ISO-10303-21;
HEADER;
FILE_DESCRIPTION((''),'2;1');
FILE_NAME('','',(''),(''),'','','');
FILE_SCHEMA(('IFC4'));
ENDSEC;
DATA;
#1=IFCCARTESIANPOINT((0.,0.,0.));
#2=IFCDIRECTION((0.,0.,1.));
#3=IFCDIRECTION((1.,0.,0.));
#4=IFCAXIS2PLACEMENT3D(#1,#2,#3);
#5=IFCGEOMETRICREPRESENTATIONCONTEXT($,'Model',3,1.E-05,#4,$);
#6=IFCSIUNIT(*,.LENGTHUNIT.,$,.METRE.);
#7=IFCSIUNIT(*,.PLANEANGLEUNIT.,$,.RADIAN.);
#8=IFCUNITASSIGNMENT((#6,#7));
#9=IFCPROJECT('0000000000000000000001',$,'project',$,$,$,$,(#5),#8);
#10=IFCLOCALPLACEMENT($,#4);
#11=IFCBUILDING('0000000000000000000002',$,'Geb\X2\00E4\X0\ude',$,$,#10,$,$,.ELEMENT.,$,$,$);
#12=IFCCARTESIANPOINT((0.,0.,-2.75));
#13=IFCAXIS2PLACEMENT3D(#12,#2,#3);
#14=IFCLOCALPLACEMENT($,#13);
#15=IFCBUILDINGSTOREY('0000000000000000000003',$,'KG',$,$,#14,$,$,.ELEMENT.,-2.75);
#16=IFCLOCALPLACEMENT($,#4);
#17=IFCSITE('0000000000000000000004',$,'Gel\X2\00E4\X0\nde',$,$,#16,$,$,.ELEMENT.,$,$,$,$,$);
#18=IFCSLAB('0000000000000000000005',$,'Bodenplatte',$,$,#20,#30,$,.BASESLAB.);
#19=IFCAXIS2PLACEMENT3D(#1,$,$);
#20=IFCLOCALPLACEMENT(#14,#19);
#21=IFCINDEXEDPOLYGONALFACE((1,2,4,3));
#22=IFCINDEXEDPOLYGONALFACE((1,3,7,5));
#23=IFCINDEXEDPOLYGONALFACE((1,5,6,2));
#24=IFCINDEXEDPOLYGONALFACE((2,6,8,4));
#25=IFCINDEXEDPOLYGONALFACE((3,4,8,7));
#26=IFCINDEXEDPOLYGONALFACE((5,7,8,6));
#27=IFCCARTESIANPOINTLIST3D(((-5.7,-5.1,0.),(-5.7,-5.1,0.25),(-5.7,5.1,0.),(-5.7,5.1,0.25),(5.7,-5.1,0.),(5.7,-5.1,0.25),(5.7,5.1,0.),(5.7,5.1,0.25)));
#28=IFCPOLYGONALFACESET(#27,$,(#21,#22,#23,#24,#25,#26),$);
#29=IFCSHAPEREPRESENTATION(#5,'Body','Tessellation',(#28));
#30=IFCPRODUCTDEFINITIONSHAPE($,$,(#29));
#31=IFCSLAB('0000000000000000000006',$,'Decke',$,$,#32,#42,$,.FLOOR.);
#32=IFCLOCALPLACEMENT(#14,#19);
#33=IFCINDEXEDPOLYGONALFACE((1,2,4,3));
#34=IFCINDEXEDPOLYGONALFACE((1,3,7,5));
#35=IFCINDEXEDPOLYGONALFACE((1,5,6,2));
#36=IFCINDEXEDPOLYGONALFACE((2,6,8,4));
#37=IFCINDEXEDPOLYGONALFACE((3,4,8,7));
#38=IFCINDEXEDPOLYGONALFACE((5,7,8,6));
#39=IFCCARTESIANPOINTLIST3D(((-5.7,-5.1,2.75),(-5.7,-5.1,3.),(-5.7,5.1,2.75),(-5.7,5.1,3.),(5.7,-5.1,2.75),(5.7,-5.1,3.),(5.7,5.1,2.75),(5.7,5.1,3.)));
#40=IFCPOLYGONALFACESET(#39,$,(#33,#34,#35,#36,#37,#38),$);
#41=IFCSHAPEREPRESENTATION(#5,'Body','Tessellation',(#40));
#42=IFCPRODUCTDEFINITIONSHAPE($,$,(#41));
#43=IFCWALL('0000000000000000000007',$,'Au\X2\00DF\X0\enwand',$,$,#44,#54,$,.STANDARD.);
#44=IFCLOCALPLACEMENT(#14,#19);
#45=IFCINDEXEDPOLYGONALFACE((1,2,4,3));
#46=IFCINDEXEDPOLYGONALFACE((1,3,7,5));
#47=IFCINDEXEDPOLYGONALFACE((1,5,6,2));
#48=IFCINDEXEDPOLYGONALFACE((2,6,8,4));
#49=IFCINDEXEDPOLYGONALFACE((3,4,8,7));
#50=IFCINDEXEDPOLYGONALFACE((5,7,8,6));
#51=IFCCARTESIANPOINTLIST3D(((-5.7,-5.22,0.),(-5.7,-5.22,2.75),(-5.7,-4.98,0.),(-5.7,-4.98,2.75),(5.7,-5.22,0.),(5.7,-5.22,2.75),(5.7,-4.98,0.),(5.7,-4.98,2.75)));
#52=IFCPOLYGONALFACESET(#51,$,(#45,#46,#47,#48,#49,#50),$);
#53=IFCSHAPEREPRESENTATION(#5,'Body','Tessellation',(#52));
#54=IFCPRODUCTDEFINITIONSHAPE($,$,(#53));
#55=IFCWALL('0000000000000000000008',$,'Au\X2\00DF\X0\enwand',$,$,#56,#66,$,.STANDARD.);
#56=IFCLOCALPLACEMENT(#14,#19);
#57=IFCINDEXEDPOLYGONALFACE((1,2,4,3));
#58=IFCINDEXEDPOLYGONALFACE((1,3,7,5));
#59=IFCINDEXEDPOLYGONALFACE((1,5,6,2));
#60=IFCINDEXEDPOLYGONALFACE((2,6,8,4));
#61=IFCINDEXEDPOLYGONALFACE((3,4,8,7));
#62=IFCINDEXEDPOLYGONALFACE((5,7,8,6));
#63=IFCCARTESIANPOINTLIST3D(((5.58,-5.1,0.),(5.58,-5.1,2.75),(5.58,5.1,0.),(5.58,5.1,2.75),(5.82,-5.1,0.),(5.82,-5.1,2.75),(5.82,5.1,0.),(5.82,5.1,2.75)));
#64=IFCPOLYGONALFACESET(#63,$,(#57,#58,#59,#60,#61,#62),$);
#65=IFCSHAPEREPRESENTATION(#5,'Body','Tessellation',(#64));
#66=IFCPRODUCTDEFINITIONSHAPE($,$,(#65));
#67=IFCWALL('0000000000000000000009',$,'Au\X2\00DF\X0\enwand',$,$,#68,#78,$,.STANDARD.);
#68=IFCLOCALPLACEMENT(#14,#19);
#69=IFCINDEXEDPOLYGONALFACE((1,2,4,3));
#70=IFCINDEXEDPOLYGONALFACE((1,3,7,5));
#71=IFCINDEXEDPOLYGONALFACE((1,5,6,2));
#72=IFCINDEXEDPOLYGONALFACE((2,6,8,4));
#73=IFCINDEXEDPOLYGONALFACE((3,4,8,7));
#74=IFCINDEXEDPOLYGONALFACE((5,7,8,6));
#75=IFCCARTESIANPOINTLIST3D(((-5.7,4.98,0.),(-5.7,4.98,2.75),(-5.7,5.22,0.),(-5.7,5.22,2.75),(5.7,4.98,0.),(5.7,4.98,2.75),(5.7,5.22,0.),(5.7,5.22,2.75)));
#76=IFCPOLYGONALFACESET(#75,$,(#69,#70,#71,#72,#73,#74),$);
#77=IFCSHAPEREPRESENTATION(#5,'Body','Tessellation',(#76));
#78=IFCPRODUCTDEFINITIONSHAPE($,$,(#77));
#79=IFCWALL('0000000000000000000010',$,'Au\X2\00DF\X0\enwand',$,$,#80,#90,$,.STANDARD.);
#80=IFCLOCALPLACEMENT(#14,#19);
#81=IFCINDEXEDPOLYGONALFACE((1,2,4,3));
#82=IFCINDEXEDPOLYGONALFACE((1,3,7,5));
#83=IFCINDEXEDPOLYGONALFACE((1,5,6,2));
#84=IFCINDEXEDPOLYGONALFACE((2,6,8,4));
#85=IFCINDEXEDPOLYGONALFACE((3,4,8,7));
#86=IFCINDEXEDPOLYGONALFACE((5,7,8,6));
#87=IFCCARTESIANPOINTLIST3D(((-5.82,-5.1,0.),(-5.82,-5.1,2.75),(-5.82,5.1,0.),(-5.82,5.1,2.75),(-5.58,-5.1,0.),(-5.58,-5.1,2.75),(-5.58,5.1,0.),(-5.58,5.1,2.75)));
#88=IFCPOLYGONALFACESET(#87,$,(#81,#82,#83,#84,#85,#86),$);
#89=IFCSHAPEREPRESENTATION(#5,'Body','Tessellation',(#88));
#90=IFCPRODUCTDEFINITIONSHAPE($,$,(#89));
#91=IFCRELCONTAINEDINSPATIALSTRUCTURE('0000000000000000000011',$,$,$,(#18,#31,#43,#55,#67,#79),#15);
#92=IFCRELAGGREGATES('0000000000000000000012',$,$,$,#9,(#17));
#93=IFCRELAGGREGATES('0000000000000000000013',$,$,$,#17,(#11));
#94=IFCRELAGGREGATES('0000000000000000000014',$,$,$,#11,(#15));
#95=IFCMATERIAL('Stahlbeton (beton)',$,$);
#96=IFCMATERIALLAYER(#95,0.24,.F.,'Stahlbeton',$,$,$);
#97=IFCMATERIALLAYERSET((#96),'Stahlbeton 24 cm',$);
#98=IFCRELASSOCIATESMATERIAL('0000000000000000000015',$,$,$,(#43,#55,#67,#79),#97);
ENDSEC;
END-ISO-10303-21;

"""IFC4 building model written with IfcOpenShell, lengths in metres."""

from ifc_helpers import new_model, si_unit, frame, origin_with_axes, origin_2d, place, context, project, spatial, polyline, rectangle, outline, extrude, material, layer, layer_set, element, save


model = new_model("IFC4")

# Units and contexts
model_context = context("Model", 3, precision=1e-05, world=origin_with_axes())
ifc_project = project(units=[si_unit("LENGTHUNIT", "METRE"), si_unit("PLANEANGLEUNIT", "RADIAN")], contexts=[model_context])

# Site, building, storey
site_placement = place(None, origin_with_axes())
site = spatial("IfcSite", under=ifc_project, at=site_placement, Name="Gelände", CompositionType="ELEMENT")
building_placement = place(None, origin_with_axes())
building = spatial("IfcBuilding", under=site, at=building_placement, Name="Gebäude", CompositionType="ELEMENT")
storey_placement = place(None, frame((0.0, 0.0, -2.75), z_axis=(0.0, 0.0, 1.0), x_axis=(1.0, 0.0, 0.0)))
storey = spatial("IfcBuildingStorey", under=building, at=storey_placement, Name="KG", CompositionType="ELEMENT", Elevation=-2.75)

# Slabs
slab_1_placement = place(None, frame((0.0, 0.0, -2.75), z_axis=(0.0, 0.0, 1.0), x_axis=(1.0, 0.0, 0.0)))
element("IfcSlab", 1, at=slab_1_placement, inside=storey, Name="Bodenplatte", PredefinedType="BASESLAB", context=model_context, shape_type="SweptSolid", body=[
    extrude(outline(polyline([(-5.7, -5.1), (5.7, -5.1), (5.7, 5.1), (-5.7, 5.1), (-5.7, -5.1)])), origin_with_axes(), (0.0, 0.0, 1.0), 0.25),
])
slab_2_placement = place(None, origin_with_axes())
element("IfcSlab", 2, at=slab_2_placement, inside=storey, Name="Decke", PredefinedType="FLOOR", context=model_context, shape_type="SweptSolid", body=[
    extrude(outline(polyline([(-5.7, -5.1), (5.7, -5.1), (5.7, 5.1), (-5.7, 5.1), (-5.7, -5.1)])), origin_with_axes(), (0.0, 0.0, 1.0), 0.25),
])

# Walls
ifc_material = material(Name="Stahlbeton (beton)")
ifc_layer = layer(ifc_material, 0.24, ventilated=False, Name="Stahlbeton")
ifc_layer_set = layer_set([ifc_layer], Name="Stahlbeton 24 cm")
wall_1_placement = place(None, frame((0.0, -5.1, -2.75), z_axis=(0.0, 0.0, 1.0), x_axis=(1.0, 0.0, 0.0)))
element("IfcWall", 3, at=wall_1_placement, inside=storey, material=ifc_layer_set, Name="Außenwand", PredefinedType="STANDARD", context=model_context, shape_type="SweptSolid", body=[
    extrude(rectangle(XDim=11.4, YDim=0.24, at=origin_2d()), origin_with_axes(), (0.0, 0.0, 1.0), 2.75),
])
wall_2_placement = place(None, frame((5.7, 0.0, -2.75), z_axis=(0.0, 0.0, 1.0), x_axis=(0.0, 1.0, 0.0)))
element("IfcWall", 4, at=wall_2_placement, inside=storey, material=ifc_layer_set, Name="Außenwand", PredefinedType="STANDARD", context=model_context, shape_type="SweptSolid", body=[
    extrude(rectangle(XDim=10.2, YDim=0.24, at=origin_2d()), origin_with_axes(), (0.0, 0.0, 1.0), 2.75),
])
wall_3_placement = place(None, frame((0.0, 5.1, -2.75), z_axis=(0.0, 0.0, 1.0), x_axis=(-1.0, 0.0, 0.0)))
element("IfcWall", 5, at=wall_3_placement, inside=storey, material=ifc_layer_set, Name="Außenwand", PredefinedType="STANDARD", context=model_context, shape_type="SweptSolid", body=[
    extrude(rectangle(XDim=11.4, YDim=0.24, at=origin_2d()), origin_with_axes(), (0.0, 0.0, 1.0), 2.75),
])
wall_4_placement = place(None, frame((-5.7, 0.0, -2.75), z_axis=(0.0, 0.0, 1.0), x_axis=(0.0, -1.0, 0.0)))
element("IfcWall", 6, at=wall_4_placement, inside=storey, material=ifc_layer_set, Name="Außenwand", PredefinedType="STANDARD", context=model_context, shape_type="SweptSolid", body=[
    extrude(rectangle(XDim=10.2, YDim=0.24, at=origin_2d()), origin_with_axes(), (0.0, 0.0, 1.0), 2.75),
])

save(model, "model.ifc")
